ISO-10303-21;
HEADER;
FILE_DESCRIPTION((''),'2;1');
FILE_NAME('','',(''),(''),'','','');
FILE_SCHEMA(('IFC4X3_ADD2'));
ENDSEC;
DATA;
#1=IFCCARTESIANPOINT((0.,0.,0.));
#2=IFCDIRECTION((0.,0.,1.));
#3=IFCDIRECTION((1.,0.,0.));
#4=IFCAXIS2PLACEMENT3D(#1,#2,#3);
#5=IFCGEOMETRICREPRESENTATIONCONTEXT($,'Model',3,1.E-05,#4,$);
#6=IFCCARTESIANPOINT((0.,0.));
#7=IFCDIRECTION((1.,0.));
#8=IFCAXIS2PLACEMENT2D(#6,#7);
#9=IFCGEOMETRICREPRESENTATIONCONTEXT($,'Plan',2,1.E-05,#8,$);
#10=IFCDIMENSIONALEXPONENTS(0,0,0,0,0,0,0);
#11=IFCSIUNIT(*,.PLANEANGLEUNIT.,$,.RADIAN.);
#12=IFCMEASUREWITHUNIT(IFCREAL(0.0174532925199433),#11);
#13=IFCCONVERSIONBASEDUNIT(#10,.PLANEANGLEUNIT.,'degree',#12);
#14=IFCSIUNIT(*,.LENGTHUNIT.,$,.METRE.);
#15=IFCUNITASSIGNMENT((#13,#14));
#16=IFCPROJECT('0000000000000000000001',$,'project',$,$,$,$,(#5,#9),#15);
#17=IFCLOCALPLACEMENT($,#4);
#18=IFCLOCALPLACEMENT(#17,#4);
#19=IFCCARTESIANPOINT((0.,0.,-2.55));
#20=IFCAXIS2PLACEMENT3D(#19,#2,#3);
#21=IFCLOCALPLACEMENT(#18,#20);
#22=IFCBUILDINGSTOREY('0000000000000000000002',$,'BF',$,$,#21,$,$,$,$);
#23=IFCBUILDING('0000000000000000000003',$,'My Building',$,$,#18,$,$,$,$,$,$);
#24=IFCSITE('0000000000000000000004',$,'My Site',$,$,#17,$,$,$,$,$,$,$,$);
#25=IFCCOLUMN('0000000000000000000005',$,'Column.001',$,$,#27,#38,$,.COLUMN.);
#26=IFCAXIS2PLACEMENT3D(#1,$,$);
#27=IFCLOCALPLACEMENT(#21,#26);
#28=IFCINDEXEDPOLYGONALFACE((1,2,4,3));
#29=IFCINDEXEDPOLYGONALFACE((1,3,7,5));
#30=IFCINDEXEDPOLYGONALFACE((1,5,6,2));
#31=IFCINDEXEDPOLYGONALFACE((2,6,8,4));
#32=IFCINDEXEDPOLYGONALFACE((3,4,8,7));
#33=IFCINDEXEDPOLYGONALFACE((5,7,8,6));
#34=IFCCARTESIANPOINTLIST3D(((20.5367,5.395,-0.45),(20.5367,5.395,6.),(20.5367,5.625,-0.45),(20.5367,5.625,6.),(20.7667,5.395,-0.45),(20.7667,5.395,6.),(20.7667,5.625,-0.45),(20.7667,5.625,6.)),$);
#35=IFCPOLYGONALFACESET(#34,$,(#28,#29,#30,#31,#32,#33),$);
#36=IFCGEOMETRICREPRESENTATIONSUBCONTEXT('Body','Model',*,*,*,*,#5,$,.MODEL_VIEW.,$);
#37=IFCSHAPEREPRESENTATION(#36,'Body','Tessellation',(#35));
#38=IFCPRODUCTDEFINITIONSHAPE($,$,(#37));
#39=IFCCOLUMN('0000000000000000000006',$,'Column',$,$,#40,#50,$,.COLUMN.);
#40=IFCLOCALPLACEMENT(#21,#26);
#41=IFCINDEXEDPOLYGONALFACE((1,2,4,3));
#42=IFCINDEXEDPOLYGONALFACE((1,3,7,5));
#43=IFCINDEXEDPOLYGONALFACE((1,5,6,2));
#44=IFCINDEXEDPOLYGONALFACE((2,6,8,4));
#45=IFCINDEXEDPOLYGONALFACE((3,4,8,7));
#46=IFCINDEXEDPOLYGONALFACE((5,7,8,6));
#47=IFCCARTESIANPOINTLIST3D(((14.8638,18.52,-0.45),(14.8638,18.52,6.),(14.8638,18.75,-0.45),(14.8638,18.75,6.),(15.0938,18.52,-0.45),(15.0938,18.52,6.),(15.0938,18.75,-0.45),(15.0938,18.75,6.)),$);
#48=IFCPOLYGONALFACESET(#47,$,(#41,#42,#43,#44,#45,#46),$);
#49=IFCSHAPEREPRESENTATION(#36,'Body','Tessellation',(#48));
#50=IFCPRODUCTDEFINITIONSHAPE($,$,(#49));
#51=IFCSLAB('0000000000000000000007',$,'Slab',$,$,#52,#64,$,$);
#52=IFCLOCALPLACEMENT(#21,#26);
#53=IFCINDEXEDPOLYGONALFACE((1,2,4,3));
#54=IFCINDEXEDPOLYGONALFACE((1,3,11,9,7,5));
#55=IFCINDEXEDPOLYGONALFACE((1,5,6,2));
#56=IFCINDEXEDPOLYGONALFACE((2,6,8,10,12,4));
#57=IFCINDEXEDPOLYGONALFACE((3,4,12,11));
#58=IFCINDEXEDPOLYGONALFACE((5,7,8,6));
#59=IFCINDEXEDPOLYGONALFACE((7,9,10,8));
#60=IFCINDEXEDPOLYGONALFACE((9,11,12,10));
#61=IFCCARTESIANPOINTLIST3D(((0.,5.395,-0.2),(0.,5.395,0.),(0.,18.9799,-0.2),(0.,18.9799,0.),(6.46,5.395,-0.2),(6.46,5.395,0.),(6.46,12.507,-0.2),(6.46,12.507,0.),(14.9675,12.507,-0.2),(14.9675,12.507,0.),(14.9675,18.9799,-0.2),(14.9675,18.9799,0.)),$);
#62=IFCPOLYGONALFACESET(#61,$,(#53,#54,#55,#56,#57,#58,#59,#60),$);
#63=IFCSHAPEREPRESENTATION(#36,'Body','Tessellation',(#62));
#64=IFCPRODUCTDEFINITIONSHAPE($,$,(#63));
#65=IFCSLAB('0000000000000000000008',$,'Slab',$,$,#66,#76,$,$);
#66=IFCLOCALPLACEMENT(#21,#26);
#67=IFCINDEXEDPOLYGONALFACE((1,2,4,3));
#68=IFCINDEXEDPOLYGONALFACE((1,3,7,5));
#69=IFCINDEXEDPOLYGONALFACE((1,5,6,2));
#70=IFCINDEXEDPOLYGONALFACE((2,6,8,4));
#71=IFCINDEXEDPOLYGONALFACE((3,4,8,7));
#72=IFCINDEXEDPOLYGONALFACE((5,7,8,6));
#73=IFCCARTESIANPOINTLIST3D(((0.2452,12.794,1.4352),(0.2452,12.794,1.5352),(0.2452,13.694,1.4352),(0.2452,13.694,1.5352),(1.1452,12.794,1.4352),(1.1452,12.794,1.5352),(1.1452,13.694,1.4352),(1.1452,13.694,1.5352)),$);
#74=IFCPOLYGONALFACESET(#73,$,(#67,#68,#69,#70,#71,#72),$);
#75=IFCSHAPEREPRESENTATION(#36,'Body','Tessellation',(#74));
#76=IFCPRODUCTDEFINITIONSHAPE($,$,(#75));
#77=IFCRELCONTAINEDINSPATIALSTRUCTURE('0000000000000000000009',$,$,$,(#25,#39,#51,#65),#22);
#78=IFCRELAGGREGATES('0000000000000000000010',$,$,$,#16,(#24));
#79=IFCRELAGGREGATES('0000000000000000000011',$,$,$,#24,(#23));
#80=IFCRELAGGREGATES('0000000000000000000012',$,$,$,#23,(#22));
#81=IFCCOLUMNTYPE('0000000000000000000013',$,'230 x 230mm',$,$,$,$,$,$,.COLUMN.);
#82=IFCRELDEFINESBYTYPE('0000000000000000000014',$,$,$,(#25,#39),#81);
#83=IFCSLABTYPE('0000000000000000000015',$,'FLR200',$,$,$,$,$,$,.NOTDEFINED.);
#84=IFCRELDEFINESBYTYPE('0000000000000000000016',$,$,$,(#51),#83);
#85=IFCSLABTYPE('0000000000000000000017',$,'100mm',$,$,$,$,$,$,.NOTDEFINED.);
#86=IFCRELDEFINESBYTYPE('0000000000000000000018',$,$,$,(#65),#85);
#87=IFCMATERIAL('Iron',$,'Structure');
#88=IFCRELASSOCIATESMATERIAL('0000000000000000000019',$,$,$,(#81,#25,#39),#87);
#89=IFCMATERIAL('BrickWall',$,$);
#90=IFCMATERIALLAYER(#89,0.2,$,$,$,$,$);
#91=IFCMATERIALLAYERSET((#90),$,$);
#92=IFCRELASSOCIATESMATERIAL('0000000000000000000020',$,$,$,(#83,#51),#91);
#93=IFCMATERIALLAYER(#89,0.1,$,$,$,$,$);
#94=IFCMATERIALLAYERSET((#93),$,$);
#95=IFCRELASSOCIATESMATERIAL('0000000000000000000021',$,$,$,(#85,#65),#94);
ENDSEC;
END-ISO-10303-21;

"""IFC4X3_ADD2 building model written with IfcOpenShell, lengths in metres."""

from ifc_helpers import new_model, entity, si_unit, converted_unit, frame, origin_with_axes, origin_2d_with_axis, place, context, subcontext, project, spatial, line, indexed_curve, rectangle, outline, extrude, material, layer, layer_set, layer_usage, material_profile, profile_set, profile_usage, type_object, element, save


model = new_model("IFC4X3_ADD2")

# Units and contexts
model_context = context("Model", 3, precision=1e-05, world=origin_with_axes())
plan_context = context("Plan", 2, precision=1e-05, world=origin_2d_with_axis())
body_context_1 = subcontext(model_context, "Body", "Model", "MODEL_VIEW")
ifc_project = project(units=[converted_unit("PLANEANGLEUNIT", "degree", entity("IfcReal", 0.0174532925199433), si_unit("PLANEANGLEUNIT", "RADIAN"), dimensions=[0, 0, 0, 0, 0, 0, 0]), si_unit("LENGTHUNIT", "METRE")], contexts=[model_context, plan_context])

# Site, building, storey
site_placement = place(None, origin_with_axes())
site = spatial("IfcSite", under=ifc_project, at=site_placement, Name="My Site")
building_placement = place(site_placement, origin_with_axes())
building = spatial("IfcBuilding", under=site, at=building_placement, Name="My Building")
storey_placement = place(building_placement, frame((0.0, 0.0, -2.55), z_axis=(0.0, 0.0, 1.0), x_axis=(1.0, 0.0, 0.0)))
storey = spatial("IfcBuildingStorey", under=building, at=storey_placement, Name="BF")

# Columns
ifc_material_1 = material(Name="Iron", Category="Structure")
ifc_material_profile = material_profile(ifc_material_1, rectangle(XDim=0.23, YDim=0.23))
ifc_profile_set = profile_set([ifc_material_profile])
column_type = type_object("IfcColumnType", Name="230 x 230mm", PredefinedType="COLUMN", material=ifc_profile_set)
ifc_profile_usage_1 = profile_usage(ifc_profile_set)
column_1_placement = place(storey_placement, frame((20.6517, 5.51, -0.45), z_axis=(0.0, 0.0, 1.0), x_axis=(1.0, 0.0, 0.0)))
element("IfcColumn", 1, at=column_1_placement, inside=storey, type_object=column_type, material=ifc_profile_usage_1, Name="Column.001", PredefinedType="COLUMN", context=body_context_1, shape_type="SweptSolid", body=[
    extrude(rectangle(XDim=0.23, YDim=0.23), origin_with_axes(), (0.0, 0.0, 1.0), 6.45),
])
ifc_profile_usage_2 = profile_usage(ifc_profile_set)
column_2_placement = place(storey_placement, frame((14.9788, 18.635, -0.45), z_axis=(0.0, 0.0, 1.0), x_axis=(1.0, 0.0, 0.0)))
element("IfcColumn", 2, at=column_2_placement, inside=storey, type_object=column_type, material=ifc_profile_usage_2, Name="Column", PredefinedType="COLUMN", context=body_context_1, shape_type="SweptSolid", body=[
    extrude(rectangle(XDim=0.23, YDim=0.23), origin_with_axes(), (0.0, 0.0, 1.0), 6.45),
])

# Slabs
ifc_material_2 = material(Name="BrickWall")
ifc_layer_1 = layer(ifc_material_2, 0.2)
ifc_layer_set_1 = layer_set([ifc_layer_1])
ifc_layer_usage_1 = layer_usage(ifc_layer_set_1, "AXIS3", "POSITIVE", 0.0)
slab_type_1 = type_object("IfcSlabType", Name="FLR200", PredefinedType="NOTDEFINED", material=ifc_layer_set_1)
slab_1_placement = place(storey_placement, frame((0.0, 5.395, -0.2), z_axis=(0.0, 0.0, 1.0), x_axis=(1.0, 0.0, 0.0)))
element("IfcSlab", 3, at=slab_1_placement, inside=storey, type_object=slab_type_1, material=ifc_layer_usage_1, Name="Slab", context=body_context_1, shape_type="SweptSolid", body=[
    extrude(outline(indexed_curve([(6.46, 0.0), (6.46, 7.112), (14.9675, 7.112), (14.9675, 13.5849), (0.0, 13.5849), (0.0, 0.0)], segments=[line(1, 6), line(6, 5), line(5, 4), line(4, 3), line(3, 2), line(2, 1)], self_intersect=False)), None, (0.0, 0.0, 1.0), 0.2),
])
ifc_layer_2 = layer(ifc_material_2, 0.1)
ifc_layer_set_2 = layer_set([ifc_layer_2])
ifc_layer_usage_2 = layer_usage(ifc_layer_set_2, "AXIS3", "POSITIVE", 0.0)
slab_type_2 = type_object("IfcSlabType", Name="100mm", PredefinedType="NOTDEFINED", material=ifc_layer_set_2)
slab_2_placement = place(storey_placement, frame((1.1452, 13.794, 1.4352), z_axis=(0.0, 0.0, 1.0), x_axis=(-1.0, 0.0, 0.0)))
element("IfcSlab", 4, at=slab_2_placement, inside=storey, type_object=slab_type_2, material=ifc_layer_usage_2, Name="Slab", context=body_context_1, shape_type="SweptSolid", body=[
    extrude(outline(indexed_curve([(0.0, 1.0), (0.9, 1.0), (0.9, 0.1), (0.0, 0.1)], segments=[line(4, 1), line(1, 2), line(2, 3), line(3, 4)], self_intersect=False)), None, (0.0, 0.0, 1.0), 0.1),
])

save(model, "model.ifc")
